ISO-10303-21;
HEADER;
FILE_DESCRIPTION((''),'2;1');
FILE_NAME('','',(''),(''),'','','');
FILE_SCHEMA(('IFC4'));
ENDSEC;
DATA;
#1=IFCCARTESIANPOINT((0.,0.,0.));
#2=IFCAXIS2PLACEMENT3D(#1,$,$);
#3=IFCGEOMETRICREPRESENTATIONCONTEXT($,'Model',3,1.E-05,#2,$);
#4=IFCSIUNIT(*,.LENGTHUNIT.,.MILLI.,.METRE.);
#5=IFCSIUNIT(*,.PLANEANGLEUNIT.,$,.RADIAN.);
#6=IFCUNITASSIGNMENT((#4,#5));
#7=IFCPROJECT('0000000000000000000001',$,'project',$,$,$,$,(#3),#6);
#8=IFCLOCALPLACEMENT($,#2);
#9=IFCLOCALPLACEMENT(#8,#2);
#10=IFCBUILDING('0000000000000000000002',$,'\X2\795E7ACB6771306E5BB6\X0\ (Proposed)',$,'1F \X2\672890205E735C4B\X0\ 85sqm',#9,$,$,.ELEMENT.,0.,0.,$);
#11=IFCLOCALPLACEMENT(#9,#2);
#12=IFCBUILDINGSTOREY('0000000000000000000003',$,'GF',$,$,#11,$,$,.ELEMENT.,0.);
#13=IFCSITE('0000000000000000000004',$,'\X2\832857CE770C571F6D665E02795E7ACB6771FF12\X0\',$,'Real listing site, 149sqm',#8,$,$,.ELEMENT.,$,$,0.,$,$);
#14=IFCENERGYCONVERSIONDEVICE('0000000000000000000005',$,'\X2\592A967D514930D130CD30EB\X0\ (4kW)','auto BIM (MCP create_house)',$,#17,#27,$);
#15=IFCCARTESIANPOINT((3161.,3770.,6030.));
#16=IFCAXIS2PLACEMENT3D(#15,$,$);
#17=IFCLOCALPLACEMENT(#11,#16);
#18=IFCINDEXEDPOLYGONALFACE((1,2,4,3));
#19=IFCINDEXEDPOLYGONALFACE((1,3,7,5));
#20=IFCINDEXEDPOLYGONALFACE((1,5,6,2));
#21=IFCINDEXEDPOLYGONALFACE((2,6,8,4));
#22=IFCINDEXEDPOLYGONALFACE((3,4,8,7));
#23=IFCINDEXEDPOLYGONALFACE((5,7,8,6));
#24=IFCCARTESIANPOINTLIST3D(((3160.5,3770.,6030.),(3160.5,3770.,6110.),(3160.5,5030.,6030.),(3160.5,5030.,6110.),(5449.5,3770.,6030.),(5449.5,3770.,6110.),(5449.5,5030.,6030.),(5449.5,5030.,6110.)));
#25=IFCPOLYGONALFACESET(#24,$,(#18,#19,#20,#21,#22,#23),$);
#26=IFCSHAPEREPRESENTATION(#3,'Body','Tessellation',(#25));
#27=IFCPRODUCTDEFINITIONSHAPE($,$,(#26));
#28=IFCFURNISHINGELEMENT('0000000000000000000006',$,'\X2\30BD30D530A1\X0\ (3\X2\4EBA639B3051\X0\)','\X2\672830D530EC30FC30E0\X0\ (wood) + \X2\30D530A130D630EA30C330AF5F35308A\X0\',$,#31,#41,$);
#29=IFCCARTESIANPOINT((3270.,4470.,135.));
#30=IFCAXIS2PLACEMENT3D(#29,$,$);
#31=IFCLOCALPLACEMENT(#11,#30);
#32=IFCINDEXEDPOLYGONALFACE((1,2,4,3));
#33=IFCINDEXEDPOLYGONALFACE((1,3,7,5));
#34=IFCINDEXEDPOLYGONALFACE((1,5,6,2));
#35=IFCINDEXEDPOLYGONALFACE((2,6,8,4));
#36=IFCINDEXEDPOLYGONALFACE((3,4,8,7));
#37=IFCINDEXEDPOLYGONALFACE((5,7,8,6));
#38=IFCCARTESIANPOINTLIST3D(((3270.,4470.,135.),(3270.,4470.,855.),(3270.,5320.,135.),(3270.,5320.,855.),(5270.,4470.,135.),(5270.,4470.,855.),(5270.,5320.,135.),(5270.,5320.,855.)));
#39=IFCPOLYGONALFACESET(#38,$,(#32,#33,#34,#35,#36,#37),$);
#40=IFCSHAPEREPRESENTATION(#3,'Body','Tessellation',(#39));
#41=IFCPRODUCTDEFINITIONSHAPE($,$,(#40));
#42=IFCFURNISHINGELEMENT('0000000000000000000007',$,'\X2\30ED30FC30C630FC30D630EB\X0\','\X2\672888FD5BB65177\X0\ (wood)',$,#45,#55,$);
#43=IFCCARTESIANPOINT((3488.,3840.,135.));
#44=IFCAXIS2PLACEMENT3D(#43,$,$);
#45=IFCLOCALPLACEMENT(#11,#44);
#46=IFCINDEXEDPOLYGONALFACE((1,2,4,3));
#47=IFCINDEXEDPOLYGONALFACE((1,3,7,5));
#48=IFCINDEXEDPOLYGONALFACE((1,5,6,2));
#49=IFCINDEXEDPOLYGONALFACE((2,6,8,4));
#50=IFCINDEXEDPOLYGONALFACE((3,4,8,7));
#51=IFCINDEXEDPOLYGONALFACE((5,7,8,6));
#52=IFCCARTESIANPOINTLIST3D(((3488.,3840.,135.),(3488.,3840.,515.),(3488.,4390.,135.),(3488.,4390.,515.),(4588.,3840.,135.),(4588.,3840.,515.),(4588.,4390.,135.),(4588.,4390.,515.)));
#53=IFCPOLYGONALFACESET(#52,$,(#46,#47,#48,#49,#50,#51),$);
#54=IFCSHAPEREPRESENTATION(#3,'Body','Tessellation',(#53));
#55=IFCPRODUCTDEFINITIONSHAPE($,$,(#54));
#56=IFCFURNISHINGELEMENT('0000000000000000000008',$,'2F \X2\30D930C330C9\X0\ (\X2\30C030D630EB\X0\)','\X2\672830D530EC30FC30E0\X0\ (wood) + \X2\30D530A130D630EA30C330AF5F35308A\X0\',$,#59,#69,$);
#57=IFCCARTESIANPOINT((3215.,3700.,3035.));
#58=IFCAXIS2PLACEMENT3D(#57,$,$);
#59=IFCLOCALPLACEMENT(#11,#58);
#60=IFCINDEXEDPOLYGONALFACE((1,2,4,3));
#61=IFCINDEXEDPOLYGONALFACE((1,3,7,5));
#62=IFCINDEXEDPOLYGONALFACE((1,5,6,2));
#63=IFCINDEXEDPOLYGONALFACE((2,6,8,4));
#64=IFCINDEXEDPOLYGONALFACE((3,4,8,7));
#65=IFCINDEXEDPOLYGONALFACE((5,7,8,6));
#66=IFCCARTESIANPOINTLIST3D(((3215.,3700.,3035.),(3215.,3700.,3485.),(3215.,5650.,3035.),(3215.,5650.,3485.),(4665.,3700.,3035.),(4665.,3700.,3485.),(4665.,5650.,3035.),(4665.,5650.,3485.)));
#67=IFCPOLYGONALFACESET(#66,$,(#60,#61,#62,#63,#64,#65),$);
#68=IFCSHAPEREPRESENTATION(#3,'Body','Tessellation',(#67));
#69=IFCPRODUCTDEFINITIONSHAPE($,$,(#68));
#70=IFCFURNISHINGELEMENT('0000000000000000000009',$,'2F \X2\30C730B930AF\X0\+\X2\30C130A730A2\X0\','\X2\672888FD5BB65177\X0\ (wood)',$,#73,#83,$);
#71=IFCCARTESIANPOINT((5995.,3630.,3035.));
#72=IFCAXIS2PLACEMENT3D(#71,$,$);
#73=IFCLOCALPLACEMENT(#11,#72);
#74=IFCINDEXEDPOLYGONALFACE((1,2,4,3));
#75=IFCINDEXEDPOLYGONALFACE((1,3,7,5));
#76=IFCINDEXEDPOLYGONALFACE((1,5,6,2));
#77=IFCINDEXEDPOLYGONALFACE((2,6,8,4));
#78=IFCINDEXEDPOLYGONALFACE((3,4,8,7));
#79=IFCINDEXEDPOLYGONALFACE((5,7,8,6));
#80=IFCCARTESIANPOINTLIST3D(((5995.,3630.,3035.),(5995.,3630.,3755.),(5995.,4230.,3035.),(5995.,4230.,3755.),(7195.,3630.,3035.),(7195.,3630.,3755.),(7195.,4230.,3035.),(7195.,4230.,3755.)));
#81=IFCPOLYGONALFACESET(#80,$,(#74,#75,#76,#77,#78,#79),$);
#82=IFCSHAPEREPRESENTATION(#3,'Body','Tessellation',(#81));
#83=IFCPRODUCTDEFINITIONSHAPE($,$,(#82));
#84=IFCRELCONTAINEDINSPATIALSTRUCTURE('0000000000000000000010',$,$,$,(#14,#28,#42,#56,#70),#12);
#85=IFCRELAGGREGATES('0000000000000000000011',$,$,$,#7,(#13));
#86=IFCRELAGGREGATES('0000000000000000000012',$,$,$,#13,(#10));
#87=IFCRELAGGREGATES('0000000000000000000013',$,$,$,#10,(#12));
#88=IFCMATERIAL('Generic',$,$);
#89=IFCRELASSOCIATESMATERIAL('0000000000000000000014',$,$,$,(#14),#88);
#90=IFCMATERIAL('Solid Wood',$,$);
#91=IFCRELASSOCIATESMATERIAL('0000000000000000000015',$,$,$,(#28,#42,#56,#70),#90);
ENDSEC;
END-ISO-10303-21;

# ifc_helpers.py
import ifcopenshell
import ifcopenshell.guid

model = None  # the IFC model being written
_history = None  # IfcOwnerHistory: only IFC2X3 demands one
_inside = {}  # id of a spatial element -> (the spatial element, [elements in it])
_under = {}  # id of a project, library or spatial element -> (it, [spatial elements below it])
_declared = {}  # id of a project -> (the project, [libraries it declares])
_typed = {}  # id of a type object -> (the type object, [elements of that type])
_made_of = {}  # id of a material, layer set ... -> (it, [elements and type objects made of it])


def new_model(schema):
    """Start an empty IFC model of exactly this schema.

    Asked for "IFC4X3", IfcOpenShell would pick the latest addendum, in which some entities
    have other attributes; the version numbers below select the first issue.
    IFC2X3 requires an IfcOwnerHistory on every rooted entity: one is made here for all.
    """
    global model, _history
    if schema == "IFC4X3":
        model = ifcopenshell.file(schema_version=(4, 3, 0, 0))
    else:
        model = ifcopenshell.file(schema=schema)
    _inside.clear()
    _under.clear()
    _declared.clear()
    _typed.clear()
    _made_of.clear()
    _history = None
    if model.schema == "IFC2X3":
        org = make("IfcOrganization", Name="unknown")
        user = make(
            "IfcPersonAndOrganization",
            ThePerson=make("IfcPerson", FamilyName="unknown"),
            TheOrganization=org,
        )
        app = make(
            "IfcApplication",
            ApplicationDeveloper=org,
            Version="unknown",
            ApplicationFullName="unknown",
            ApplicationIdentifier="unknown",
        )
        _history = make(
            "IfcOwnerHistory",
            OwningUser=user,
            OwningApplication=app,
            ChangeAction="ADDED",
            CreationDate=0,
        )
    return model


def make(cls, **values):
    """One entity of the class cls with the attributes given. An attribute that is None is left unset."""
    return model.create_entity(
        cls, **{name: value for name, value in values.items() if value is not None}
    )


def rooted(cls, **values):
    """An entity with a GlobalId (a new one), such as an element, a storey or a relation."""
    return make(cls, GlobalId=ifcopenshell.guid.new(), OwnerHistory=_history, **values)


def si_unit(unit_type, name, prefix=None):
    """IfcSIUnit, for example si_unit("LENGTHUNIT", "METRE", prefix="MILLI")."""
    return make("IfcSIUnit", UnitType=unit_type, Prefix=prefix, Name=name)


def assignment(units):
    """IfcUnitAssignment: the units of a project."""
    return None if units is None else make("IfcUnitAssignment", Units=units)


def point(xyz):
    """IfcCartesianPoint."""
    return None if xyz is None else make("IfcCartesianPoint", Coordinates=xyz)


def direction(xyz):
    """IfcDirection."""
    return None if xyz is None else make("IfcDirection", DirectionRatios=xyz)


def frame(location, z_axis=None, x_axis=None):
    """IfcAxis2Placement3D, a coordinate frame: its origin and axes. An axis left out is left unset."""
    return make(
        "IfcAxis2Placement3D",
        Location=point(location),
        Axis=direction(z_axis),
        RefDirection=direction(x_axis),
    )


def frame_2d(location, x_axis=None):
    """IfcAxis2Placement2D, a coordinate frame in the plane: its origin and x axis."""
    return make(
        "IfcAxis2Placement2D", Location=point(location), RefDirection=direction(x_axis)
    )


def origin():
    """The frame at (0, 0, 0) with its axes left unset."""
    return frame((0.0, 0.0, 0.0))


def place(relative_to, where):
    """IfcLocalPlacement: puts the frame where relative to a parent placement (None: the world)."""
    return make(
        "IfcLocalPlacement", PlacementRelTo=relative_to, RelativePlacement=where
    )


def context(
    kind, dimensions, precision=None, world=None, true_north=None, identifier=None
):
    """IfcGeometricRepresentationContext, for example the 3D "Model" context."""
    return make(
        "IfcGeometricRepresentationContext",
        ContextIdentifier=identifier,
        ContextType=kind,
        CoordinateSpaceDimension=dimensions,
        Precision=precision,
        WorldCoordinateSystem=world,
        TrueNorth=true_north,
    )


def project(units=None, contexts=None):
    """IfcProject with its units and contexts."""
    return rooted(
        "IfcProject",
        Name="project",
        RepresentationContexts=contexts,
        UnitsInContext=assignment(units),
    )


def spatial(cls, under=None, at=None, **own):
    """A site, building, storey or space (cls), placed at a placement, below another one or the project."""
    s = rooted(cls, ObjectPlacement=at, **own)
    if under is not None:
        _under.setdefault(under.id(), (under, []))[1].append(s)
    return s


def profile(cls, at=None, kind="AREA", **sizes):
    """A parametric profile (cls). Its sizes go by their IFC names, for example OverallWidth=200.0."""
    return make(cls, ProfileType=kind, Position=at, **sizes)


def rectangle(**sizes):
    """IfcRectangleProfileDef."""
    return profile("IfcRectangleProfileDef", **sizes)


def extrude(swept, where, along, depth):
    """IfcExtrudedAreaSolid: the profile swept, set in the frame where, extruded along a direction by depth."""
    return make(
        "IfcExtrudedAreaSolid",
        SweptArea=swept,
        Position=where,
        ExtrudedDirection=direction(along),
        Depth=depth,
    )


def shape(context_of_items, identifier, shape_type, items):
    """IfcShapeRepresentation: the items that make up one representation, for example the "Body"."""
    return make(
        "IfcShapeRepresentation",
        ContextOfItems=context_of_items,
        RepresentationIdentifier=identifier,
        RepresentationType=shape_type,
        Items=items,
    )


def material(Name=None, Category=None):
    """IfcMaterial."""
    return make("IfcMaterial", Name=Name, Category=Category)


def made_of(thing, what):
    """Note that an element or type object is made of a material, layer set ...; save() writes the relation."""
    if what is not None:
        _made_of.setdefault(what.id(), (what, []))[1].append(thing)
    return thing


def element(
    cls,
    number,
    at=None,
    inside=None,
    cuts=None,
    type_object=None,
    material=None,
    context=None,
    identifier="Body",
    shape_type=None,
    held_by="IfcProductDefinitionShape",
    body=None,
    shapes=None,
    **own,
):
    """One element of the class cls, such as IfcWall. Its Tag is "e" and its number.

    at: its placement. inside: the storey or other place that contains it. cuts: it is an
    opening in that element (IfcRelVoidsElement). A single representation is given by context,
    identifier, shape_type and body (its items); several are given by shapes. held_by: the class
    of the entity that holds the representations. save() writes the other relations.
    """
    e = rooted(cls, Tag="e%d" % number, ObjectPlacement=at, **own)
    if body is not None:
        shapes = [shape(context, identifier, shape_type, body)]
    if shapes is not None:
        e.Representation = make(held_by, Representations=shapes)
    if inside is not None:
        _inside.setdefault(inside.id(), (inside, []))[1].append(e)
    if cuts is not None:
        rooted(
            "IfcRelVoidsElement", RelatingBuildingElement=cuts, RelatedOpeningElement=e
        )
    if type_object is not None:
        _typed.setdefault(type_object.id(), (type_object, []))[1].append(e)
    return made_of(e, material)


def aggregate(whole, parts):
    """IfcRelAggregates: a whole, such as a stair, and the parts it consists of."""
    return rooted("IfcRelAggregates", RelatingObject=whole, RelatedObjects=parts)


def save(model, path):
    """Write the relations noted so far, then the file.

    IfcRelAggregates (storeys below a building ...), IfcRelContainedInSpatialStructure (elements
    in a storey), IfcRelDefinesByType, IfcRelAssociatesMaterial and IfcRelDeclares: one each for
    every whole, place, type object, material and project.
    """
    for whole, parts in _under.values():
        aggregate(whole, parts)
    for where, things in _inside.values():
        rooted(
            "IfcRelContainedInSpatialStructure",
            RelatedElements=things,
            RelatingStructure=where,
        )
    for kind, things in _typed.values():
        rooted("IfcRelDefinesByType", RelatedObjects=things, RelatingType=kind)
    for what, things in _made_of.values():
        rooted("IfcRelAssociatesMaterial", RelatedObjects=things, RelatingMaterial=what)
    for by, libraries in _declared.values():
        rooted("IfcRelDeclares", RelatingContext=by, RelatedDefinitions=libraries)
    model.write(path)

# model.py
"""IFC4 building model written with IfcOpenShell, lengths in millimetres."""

from ifc_helpers import new_model, si_unit, frame, frame_2d, origin, place, context, project, spatial, rectangle, extrude, material, element, save


model = new_model("IFC4")

# Units and contexts
model_context = context("Model", 3, precision=1e-05, world=origin())
ifc_project = project(units=[si_unit("LENGTHUNIT", "METRE", prefix="MILLI"), si_unit("PLANEANGLEUNIT", "RADIAN")], contexts=[model_context])

# Site, building, storey
site_placement = place(None, origin())
site = spatial("IfcSite", under=ifc_project, at=site_placement, Name="茨城県土浦市神立東２", ObjectType="Real listing site, 149sqm", CompositionType="ELEMENT", RefElevation=0.0)
building_placement = place(site_placement, origin())
building = spatial("IfcBuilding", under=site, at=building_placement, Name="神立東の家 (Proposed)", ObjectType="1F 木造平屋 85sqm", CompositionType="ELEMENT", ElevationOfRefHeight=0.0, ElevationOfTerrain=0.0)
storey_placement = place(building_placement, origin())
storey = spatial("IfcBuildingStorey", under=building, at=storey_placement, Name="GF", CompositionType="ELEMENT", Elevation=0.0)

# Shared definitions
ifc_material_1 = material(Name="Solid Wood")

# Shared definitions
ifc_material_2 = material(Name="Generic")

# Energy conversion device
energy_conversion_device_placement = place(storey_placement, frame((3161.0, 3770.0, 6030.0)))
element("IfcEnergyConversionDevice", 1, at=energy_conversion_device_placement, inside=storey, material=ifc_material_2, Name="太陽光パネル (4kW)", Description="auto BIM (MCP create_house)", context=model_context, shape_type="SweptSolid", body=[
    extrude(rectangle(XDim=2289.0, YDim=1260.0, at=frame_2d((1144.0, 630.0))), frame((3161.0, 3770.0, 6030.0)), (0.0, 0.0, 1.0), 80.0),
])

# Furnishing elements
furnishing_1_placement = place(storey_placement, frame((3270.0, 4470.0, 135.0)))
element("IfcFurnishingElement", 2, at=furnishing_1_placement, inside=storey, material=ifc_material_1, Name="ソファ (3人掛け)", Description="木フレーム (wood) + ファブリック張り", context=model_context, shape_type="SweptSolid", body=[
    extrude(rectangle(XDim=2000.0, YDim=850.0, at=frame_2d((1000.0, 425.0))), frame((3270.0, 4470.0, 135.0)), (0.0, 0.0, 1.0), 720.0),
])
furnishing_2_placement = place(storey_placement, frame((3488.0, 3840.0, 135.0)))
element("IfcFurnishingElement", 3, at=furnishing_2_placement, inside=storey, material=ifc_material_1, Name="ローテーブル", Description="木製家具 (wood)", context=model_context, shape_type="SweptSolid", body=[
    extrude(rectangle(XDim=1100.0, YDim=550.0, at=frame_2d((550.0, 275.0))), frame((3488.0, 3840.0, 135.0)), (0.0, 0.0, 1.0), 380.0),
])
furnishing_3_placement = place(storey_placement, frame((3215.0, 3700.0, 3035.0)))
element("IfcFurnishingElement", 4, at=furnishing_3_placement, inside=storey, material=ifc_material_1, Name="2F ベッド (ダブル)", Description="木フレーム (wood) + ファブリック張り", context=model_context, shape_type="SweptSolid", body=[
    extrude(rectangle(XDim=1450.0, YDim=1950.0, at=frame_2d((725.0, 975.0))), frame((3215.0, 3700.0, 3035.0)), (0.0, 0.0, 1.0), 450.0),
])
furnishing_4_placement = place(storey_placement, frame((5995.0, 3630.0, 3035.0)))
element("IfcFurnishingElement", 5, at=furnishing_4_placement, inside=storey, material=ifc_material_1, Name="2F デスク+チェア", Description="木製家具 (wood)", context=model_context, shape_type="SweptSolid", body=[
    extrude(rectangle(XDim=1200.0, YDim=600.0, at=frame_2d((600.0, 300.0))), frame((5995.0, 3630.0, 3035.0)), (0.0, 0.0, 1.0), 720.0),
])

save(model, "model.ifc")
